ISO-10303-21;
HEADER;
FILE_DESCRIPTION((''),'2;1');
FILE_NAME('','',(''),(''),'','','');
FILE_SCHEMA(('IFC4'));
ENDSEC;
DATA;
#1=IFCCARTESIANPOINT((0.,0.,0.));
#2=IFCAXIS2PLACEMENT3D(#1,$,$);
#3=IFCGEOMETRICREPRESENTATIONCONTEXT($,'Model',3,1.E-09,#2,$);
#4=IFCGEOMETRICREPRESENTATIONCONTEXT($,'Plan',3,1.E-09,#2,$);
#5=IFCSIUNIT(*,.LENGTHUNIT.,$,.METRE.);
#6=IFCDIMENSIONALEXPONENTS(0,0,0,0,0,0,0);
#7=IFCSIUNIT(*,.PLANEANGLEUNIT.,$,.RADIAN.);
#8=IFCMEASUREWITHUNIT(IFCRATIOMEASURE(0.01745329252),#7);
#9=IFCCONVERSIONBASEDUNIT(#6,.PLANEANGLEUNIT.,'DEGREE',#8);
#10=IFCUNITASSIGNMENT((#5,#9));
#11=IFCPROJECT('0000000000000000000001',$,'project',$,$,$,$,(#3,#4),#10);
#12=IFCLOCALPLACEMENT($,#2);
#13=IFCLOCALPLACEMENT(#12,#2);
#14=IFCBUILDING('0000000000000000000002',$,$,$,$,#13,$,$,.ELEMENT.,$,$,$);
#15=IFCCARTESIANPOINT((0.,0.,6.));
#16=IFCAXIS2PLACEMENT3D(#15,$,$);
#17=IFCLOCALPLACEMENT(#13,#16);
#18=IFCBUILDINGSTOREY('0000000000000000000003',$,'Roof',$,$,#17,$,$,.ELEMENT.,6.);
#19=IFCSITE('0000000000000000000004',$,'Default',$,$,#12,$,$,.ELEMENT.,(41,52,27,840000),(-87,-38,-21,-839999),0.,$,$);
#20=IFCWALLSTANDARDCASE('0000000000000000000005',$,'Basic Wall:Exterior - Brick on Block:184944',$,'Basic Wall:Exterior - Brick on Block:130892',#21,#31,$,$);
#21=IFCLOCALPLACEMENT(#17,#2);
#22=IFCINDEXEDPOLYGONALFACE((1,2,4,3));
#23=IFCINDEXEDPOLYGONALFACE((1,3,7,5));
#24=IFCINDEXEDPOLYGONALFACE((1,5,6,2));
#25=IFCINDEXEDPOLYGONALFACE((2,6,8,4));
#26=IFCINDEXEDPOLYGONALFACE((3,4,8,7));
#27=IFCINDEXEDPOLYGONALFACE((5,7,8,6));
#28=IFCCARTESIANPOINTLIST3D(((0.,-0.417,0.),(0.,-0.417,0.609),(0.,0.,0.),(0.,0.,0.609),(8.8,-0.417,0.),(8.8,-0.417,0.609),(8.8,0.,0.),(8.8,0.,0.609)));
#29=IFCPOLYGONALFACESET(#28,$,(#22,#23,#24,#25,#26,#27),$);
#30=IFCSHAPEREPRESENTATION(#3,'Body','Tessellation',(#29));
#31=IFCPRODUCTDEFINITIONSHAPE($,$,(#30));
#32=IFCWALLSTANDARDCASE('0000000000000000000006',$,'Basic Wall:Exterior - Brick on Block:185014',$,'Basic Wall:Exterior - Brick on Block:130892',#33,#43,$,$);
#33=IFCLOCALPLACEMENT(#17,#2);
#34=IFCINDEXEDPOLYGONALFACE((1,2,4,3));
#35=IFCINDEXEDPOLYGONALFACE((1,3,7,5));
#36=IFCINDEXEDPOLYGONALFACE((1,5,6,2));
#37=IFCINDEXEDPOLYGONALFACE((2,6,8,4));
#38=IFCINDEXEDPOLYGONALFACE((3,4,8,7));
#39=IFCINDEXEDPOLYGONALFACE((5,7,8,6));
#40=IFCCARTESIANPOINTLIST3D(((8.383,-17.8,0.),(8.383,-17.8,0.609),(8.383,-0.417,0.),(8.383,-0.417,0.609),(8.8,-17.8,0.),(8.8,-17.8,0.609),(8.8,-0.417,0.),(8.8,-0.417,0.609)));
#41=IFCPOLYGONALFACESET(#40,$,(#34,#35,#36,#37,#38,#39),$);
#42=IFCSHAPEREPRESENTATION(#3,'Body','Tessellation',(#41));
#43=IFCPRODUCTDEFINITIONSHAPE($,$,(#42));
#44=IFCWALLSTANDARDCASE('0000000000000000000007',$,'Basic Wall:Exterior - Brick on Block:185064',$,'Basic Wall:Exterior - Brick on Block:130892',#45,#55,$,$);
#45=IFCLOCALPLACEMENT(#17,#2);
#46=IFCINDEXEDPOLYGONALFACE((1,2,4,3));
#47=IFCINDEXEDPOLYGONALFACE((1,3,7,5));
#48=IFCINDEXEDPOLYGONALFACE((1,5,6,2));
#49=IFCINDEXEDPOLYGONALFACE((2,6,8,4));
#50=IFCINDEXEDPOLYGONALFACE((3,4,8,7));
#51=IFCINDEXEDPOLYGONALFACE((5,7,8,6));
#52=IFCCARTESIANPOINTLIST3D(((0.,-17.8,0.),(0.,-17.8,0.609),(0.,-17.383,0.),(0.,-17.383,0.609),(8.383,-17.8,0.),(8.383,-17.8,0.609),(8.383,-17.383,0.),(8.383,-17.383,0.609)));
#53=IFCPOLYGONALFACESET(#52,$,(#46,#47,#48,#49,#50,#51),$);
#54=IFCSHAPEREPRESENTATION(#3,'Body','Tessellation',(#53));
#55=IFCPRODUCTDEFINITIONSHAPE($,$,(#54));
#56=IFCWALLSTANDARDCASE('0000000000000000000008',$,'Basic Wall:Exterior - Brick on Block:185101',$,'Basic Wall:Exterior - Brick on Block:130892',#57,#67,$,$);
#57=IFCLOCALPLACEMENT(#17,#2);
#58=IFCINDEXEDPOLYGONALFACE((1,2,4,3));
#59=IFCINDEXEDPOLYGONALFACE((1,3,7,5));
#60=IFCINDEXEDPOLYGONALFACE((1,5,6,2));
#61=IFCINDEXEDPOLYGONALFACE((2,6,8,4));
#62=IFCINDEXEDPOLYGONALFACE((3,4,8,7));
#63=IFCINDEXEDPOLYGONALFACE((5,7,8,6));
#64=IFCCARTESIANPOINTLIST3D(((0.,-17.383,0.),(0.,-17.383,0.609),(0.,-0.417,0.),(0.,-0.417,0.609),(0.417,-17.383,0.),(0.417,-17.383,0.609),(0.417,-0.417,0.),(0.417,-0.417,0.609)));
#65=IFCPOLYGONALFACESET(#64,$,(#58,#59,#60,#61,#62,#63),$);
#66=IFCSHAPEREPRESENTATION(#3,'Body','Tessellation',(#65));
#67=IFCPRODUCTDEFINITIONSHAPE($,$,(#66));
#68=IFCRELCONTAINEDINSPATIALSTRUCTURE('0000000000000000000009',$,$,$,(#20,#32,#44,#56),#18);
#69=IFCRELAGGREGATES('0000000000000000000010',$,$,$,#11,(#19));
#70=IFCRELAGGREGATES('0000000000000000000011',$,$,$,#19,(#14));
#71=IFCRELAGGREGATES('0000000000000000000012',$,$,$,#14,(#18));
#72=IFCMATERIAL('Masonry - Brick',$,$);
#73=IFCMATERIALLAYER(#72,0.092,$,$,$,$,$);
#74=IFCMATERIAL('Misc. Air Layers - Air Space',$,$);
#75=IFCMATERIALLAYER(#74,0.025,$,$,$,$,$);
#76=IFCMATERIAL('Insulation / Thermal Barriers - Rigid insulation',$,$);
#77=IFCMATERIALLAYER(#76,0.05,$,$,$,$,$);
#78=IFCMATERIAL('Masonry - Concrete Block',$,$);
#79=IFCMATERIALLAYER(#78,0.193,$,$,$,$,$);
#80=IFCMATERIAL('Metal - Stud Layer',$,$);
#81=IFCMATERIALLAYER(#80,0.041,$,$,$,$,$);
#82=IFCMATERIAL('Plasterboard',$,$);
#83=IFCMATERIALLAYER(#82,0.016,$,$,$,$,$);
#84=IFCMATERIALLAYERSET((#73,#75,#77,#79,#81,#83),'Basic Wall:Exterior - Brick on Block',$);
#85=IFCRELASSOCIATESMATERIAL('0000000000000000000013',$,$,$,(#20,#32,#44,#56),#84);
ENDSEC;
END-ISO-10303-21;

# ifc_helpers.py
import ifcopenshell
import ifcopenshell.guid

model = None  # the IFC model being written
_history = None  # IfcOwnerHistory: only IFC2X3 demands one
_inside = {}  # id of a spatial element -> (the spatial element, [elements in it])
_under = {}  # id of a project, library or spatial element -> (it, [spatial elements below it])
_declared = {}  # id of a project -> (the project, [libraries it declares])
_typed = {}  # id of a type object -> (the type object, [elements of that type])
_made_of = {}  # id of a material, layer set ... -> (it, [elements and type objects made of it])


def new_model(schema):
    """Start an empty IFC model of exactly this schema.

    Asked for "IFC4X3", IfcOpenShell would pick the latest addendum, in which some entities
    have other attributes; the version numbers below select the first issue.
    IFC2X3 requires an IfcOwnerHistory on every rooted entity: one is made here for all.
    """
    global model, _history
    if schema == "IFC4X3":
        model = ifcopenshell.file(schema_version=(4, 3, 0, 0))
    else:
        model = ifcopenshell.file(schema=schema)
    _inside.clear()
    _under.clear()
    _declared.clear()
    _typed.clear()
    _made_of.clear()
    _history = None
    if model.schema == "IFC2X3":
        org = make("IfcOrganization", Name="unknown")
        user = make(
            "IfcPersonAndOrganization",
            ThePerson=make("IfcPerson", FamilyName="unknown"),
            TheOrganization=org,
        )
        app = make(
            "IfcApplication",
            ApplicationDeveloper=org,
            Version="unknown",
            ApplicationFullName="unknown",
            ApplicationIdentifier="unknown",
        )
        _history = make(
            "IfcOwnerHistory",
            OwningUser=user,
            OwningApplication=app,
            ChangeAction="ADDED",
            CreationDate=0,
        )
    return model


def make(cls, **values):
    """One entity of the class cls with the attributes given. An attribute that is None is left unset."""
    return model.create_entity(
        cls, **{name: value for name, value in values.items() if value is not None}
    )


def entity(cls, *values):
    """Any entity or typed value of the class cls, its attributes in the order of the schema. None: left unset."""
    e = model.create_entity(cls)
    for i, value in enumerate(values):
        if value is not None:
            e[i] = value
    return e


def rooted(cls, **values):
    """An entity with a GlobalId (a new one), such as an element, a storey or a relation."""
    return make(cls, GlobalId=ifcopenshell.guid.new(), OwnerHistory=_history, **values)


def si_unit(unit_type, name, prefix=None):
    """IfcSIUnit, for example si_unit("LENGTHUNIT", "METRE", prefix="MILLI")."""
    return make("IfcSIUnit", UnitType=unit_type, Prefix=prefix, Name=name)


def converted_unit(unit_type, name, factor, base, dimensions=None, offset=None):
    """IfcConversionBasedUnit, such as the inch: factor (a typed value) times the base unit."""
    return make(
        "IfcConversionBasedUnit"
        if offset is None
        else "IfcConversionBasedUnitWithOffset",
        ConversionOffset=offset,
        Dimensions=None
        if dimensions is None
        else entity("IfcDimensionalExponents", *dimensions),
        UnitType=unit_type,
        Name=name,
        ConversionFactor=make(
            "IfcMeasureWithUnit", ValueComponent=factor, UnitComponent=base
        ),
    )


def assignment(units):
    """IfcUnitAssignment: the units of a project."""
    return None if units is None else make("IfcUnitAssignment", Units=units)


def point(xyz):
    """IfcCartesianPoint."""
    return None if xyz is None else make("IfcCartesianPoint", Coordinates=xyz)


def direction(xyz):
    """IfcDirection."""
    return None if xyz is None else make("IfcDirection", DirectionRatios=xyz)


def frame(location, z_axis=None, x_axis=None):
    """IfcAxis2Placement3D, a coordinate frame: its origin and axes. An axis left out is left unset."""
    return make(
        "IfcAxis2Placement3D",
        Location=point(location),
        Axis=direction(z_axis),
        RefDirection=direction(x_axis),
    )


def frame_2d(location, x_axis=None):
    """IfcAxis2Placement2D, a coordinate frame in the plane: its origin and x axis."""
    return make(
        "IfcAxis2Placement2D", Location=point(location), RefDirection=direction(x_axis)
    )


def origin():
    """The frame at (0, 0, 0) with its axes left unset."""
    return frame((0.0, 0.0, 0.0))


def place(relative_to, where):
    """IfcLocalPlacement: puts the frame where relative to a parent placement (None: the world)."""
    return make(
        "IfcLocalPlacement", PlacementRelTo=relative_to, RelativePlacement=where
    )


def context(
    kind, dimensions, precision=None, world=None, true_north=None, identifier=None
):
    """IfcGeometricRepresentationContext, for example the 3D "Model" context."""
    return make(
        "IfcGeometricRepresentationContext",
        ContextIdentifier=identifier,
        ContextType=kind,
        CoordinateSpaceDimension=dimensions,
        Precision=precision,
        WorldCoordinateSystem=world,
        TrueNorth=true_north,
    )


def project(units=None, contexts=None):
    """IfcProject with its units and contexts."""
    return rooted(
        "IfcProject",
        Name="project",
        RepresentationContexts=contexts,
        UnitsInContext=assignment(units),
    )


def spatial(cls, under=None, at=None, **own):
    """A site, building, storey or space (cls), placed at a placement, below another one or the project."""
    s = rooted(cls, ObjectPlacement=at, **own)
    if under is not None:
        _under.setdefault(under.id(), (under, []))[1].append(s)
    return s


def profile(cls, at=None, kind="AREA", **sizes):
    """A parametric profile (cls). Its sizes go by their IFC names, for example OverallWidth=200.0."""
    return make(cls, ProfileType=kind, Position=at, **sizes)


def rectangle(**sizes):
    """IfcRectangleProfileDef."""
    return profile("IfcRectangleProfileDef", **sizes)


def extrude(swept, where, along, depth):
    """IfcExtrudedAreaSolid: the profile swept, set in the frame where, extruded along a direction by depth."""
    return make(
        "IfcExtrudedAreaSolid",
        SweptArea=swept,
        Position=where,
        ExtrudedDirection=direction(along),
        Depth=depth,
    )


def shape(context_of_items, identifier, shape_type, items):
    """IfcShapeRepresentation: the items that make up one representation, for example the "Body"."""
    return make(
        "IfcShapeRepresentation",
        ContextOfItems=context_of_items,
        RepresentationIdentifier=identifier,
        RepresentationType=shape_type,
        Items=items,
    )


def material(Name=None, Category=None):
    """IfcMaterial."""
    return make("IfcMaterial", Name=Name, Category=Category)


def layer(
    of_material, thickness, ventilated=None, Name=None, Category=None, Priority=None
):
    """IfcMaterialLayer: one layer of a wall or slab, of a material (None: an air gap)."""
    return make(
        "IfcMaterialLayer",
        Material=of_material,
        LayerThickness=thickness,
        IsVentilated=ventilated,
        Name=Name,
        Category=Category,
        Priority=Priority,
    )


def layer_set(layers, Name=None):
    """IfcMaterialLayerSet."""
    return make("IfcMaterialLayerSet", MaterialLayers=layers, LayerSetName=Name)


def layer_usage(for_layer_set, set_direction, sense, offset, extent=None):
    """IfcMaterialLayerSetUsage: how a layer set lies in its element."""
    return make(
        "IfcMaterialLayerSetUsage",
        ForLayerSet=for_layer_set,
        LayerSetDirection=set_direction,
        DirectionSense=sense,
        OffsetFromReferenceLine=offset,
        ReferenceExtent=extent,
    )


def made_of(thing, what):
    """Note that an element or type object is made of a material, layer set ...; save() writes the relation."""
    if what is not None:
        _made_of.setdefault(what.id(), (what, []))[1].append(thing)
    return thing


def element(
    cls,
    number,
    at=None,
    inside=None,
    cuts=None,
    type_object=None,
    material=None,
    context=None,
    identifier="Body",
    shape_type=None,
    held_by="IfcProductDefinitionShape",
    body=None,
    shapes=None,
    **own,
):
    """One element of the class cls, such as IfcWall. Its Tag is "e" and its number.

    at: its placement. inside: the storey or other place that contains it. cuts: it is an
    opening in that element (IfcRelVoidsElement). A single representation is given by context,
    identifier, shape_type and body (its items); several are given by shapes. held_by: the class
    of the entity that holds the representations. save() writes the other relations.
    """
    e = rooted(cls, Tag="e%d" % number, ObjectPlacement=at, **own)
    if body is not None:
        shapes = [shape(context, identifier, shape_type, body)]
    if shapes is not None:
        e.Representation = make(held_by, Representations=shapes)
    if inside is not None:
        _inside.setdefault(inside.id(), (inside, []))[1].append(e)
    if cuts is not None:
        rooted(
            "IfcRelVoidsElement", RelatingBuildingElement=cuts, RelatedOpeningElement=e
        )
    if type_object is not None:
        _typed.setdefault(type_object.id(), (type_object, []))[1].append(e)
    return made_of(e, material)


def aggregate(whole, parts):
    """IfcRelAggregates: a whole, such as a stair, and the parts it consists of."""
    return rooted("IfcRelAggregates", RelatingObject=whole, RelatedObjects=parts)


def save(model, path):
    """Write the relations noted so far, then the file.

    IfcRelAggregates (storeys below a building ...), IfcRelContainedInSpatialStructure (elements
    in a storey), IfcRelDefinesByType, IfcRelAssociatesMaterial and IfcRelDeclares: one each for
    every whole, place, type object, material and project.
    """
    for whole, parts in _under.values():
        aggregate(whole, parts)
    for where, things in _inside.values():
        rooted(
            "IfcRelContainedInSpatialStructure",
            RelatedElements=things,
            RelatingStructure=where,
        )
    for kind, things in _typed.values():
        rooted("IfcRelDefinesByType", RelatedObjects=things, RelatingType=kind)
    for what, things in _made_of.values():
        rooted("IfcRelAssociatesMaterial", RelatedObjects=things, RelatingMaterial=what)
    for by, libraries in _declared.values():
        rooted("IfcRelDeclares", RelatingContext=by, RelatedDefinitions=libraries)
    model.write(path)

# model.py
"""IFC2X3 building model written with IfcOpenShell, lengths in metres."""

from ifc_helpers import new_model, entity, si_unit, converted_unit, frame, frame_2d, origin, place, context, project, spatial, rectangle, extrude, material, layer, layer_set, layer_usage, element, save


model = new_model("IFC2X3")

# Units and contexts
model_context = context("Model", 3, precision=1e-09, world=origin())
plan_context = context("Plan", 3, precision=1e-09, world=origin())
ifc_project = project(units=[si_unit("LENGTHUNIT", "METRE"), converted_unit("PLANEANGLEUNIT", "DEGREE", entity("IfcRatioMeasure", 0.01745329252), si_unit("PLANEANGLEUNIT", "RADIAN"), dimensions=[0, 0, 0, 0, 0, 0, 0])], contexts=[model_context, plan_context])

# Site, building, storey
site_placement = place(None, origin())
site = spatial("IfcSite", under=ifc_project, at=site_placement, Name="Default", CompositionType="ELEMENT", RefLatitude=(41, 52, 27, 840000), RefLongitude=(-87, -38, -21, -839999), RefElevation=0.0)
building_placement = place(site_placement, origin())
building = spatial("IfcBuilding", under=site, at=building_placement, CompositionType="ELEMENT")
storey_placement = place(building_placement, frame((0.0, 0.0, 6.0)))
storey = spatial("IfcBuildingStorey", under=building, at=storey_placement, Name="Roof", CompositionType="ELEMENT", Elevation=6.0)

# Walls
ifc_material_1 = material(Name="Masonry - Brick")
ifc_layer_1 = layer(ifc_material_1, 0.092)
ifc_material_2 = material(Name="Misc. Air Layers - Air Space")
ifc_layer_2 = layer(ifc_material_2, 0.025)
ifc_material_3 = material(Name="Insulation / Thermal Barriers - Rigid insulation")
ifc_layer_3 = layer(ifc_material_3, 0.05)
ifc_material_4 = material(Name="Masonry - Concrete Block")
ifc_layer_4 = layer(ifc_material_4, 0.193)
ifc_material_5 = material(Name="Metal - Stud Layer")
ifc_layer_5 = layer(ifc_material_5, 0.041)
ifc_material_6 = material(Name="Plasterboard")
ifc_layer_6 = layer(ifc_material_6, 0.016)
ifc_layer_set = layer_set([ifc_layer_1, ifc_layer_2, ifc_layer_3, ifc_layer_4, ifc_layer_5, ifc_layer_6], Name="Basic Wall:Exterior - Brick on Block")
ifc_layer_usage_1 = layer_usage(ifc_layer_set, "AXIS2", "NEGATIVE", 0.2085)
wall_1_placement = place(storey_placement, frame((0.0, -0.2085, 0.0)))
element("IfcWallStandardCase", 1, at=wall_1_placement, inside=storey, material=ifc_layer_usage_1, Name="Basic Wall:Exterior - Brick on Block:184944", ObjectType="Basic Wall:Exterior - Brick on Block:130892", context=model_context, shape_type="SweptSolid", body=[
    extrude(rectangle(XDim=8.8, YDim=0.417, at=frame_2d((4.4, 0.0), x_axis=(-1.0, 0.0))), origin(), (0.0, 0.0, 1.0), 0.609),
])
ifc_layer_usage_2 = layer_usage(ifc_layer_set, "AXIS2", "NEGATIVE", 0.2085)
wall_2_placement = place(storey_placement, frame((8.5915, -0.417, 0.0), z_axis=(0.0, 0.0, 1.0), x_axis=(0.0, -1.0, 0.0)))
element("IfcWallStandardCase", 2, at=wall_2_placement, inside=storey, material=ifc_layer_usage_2, Name="Basic Wall:Exterior - Brick on Block:185014", ObjectType="Basic Wall:Exterior - Brick on Block:130892", context=model_context, shape_type="SweptSolid", body=[
    extrude(rectangle(XDim=17.383, YDim=0.417, at=frame_2d((8.6915, 0.0), x_axis=(-1.0, 0.0))), origin(), (0.0, 0.0, 1.0), 0.609),
])
ifc_layer_usage_3 = layer_usage(ifc_layer_set, "AXIS2", "NEGATIVE", 0.2085)
wall_3_placement = place(storey_placement, frame((8.383, -17.5915, 0.0), z_axis=(0.0, 0.0, 1.0), x_axis=(-1.0, 0.0, 0.0)))
element("IfcWallStandardCase", 3, at=wall_3_placement, inside=storey, material=ifc_layer_usage_3, Name="Basic Wall:Exterior - Brick on Block:185064", ObjectType="Basic Wall:Exterior - Brick on Block:130892", context=model_context, shape_type="SweptSolid", body=[
    extrude(rectangle(XDim=8.383, YDim=0.417, at=frame_2d((4.1915, 0.0), x_axis=(-1.0, 0.0))), origin(), (0.0, 0.0, 1.0), 0.609),
])
ifc_layer_usage_4 = layer_usage(ifc_layer_set, "AXIS2", "NEGATIVE", 0.2085)
wall_4_placement = place(storey_placement, frame((0.2085, -17.383, 0.0), z_axis=(0.0, 0.0, 1.0), x_axis=(0.0, 1.0, 0.0)))
element("IfcWallStandardCase", 4, at=wall_4_placement, inside=storey, material=ifc_layer_usage_4, Name="Basic Wall:Exterior - Brick on Block:185101", ObjectType="Basic Wall:Exterior - Brick on Block:130892", context=model_context, shape_type="SweptSolid", body=[
    extrude(rectangle(XDim=16.966, YDim=0.417, at=frame_2d((8.483, 0.0), x_axis=(-1.0, 0.0))), origin(), (0.0, 0.0, 1.0), 0.609),
])

save(model, "model.ifc")
